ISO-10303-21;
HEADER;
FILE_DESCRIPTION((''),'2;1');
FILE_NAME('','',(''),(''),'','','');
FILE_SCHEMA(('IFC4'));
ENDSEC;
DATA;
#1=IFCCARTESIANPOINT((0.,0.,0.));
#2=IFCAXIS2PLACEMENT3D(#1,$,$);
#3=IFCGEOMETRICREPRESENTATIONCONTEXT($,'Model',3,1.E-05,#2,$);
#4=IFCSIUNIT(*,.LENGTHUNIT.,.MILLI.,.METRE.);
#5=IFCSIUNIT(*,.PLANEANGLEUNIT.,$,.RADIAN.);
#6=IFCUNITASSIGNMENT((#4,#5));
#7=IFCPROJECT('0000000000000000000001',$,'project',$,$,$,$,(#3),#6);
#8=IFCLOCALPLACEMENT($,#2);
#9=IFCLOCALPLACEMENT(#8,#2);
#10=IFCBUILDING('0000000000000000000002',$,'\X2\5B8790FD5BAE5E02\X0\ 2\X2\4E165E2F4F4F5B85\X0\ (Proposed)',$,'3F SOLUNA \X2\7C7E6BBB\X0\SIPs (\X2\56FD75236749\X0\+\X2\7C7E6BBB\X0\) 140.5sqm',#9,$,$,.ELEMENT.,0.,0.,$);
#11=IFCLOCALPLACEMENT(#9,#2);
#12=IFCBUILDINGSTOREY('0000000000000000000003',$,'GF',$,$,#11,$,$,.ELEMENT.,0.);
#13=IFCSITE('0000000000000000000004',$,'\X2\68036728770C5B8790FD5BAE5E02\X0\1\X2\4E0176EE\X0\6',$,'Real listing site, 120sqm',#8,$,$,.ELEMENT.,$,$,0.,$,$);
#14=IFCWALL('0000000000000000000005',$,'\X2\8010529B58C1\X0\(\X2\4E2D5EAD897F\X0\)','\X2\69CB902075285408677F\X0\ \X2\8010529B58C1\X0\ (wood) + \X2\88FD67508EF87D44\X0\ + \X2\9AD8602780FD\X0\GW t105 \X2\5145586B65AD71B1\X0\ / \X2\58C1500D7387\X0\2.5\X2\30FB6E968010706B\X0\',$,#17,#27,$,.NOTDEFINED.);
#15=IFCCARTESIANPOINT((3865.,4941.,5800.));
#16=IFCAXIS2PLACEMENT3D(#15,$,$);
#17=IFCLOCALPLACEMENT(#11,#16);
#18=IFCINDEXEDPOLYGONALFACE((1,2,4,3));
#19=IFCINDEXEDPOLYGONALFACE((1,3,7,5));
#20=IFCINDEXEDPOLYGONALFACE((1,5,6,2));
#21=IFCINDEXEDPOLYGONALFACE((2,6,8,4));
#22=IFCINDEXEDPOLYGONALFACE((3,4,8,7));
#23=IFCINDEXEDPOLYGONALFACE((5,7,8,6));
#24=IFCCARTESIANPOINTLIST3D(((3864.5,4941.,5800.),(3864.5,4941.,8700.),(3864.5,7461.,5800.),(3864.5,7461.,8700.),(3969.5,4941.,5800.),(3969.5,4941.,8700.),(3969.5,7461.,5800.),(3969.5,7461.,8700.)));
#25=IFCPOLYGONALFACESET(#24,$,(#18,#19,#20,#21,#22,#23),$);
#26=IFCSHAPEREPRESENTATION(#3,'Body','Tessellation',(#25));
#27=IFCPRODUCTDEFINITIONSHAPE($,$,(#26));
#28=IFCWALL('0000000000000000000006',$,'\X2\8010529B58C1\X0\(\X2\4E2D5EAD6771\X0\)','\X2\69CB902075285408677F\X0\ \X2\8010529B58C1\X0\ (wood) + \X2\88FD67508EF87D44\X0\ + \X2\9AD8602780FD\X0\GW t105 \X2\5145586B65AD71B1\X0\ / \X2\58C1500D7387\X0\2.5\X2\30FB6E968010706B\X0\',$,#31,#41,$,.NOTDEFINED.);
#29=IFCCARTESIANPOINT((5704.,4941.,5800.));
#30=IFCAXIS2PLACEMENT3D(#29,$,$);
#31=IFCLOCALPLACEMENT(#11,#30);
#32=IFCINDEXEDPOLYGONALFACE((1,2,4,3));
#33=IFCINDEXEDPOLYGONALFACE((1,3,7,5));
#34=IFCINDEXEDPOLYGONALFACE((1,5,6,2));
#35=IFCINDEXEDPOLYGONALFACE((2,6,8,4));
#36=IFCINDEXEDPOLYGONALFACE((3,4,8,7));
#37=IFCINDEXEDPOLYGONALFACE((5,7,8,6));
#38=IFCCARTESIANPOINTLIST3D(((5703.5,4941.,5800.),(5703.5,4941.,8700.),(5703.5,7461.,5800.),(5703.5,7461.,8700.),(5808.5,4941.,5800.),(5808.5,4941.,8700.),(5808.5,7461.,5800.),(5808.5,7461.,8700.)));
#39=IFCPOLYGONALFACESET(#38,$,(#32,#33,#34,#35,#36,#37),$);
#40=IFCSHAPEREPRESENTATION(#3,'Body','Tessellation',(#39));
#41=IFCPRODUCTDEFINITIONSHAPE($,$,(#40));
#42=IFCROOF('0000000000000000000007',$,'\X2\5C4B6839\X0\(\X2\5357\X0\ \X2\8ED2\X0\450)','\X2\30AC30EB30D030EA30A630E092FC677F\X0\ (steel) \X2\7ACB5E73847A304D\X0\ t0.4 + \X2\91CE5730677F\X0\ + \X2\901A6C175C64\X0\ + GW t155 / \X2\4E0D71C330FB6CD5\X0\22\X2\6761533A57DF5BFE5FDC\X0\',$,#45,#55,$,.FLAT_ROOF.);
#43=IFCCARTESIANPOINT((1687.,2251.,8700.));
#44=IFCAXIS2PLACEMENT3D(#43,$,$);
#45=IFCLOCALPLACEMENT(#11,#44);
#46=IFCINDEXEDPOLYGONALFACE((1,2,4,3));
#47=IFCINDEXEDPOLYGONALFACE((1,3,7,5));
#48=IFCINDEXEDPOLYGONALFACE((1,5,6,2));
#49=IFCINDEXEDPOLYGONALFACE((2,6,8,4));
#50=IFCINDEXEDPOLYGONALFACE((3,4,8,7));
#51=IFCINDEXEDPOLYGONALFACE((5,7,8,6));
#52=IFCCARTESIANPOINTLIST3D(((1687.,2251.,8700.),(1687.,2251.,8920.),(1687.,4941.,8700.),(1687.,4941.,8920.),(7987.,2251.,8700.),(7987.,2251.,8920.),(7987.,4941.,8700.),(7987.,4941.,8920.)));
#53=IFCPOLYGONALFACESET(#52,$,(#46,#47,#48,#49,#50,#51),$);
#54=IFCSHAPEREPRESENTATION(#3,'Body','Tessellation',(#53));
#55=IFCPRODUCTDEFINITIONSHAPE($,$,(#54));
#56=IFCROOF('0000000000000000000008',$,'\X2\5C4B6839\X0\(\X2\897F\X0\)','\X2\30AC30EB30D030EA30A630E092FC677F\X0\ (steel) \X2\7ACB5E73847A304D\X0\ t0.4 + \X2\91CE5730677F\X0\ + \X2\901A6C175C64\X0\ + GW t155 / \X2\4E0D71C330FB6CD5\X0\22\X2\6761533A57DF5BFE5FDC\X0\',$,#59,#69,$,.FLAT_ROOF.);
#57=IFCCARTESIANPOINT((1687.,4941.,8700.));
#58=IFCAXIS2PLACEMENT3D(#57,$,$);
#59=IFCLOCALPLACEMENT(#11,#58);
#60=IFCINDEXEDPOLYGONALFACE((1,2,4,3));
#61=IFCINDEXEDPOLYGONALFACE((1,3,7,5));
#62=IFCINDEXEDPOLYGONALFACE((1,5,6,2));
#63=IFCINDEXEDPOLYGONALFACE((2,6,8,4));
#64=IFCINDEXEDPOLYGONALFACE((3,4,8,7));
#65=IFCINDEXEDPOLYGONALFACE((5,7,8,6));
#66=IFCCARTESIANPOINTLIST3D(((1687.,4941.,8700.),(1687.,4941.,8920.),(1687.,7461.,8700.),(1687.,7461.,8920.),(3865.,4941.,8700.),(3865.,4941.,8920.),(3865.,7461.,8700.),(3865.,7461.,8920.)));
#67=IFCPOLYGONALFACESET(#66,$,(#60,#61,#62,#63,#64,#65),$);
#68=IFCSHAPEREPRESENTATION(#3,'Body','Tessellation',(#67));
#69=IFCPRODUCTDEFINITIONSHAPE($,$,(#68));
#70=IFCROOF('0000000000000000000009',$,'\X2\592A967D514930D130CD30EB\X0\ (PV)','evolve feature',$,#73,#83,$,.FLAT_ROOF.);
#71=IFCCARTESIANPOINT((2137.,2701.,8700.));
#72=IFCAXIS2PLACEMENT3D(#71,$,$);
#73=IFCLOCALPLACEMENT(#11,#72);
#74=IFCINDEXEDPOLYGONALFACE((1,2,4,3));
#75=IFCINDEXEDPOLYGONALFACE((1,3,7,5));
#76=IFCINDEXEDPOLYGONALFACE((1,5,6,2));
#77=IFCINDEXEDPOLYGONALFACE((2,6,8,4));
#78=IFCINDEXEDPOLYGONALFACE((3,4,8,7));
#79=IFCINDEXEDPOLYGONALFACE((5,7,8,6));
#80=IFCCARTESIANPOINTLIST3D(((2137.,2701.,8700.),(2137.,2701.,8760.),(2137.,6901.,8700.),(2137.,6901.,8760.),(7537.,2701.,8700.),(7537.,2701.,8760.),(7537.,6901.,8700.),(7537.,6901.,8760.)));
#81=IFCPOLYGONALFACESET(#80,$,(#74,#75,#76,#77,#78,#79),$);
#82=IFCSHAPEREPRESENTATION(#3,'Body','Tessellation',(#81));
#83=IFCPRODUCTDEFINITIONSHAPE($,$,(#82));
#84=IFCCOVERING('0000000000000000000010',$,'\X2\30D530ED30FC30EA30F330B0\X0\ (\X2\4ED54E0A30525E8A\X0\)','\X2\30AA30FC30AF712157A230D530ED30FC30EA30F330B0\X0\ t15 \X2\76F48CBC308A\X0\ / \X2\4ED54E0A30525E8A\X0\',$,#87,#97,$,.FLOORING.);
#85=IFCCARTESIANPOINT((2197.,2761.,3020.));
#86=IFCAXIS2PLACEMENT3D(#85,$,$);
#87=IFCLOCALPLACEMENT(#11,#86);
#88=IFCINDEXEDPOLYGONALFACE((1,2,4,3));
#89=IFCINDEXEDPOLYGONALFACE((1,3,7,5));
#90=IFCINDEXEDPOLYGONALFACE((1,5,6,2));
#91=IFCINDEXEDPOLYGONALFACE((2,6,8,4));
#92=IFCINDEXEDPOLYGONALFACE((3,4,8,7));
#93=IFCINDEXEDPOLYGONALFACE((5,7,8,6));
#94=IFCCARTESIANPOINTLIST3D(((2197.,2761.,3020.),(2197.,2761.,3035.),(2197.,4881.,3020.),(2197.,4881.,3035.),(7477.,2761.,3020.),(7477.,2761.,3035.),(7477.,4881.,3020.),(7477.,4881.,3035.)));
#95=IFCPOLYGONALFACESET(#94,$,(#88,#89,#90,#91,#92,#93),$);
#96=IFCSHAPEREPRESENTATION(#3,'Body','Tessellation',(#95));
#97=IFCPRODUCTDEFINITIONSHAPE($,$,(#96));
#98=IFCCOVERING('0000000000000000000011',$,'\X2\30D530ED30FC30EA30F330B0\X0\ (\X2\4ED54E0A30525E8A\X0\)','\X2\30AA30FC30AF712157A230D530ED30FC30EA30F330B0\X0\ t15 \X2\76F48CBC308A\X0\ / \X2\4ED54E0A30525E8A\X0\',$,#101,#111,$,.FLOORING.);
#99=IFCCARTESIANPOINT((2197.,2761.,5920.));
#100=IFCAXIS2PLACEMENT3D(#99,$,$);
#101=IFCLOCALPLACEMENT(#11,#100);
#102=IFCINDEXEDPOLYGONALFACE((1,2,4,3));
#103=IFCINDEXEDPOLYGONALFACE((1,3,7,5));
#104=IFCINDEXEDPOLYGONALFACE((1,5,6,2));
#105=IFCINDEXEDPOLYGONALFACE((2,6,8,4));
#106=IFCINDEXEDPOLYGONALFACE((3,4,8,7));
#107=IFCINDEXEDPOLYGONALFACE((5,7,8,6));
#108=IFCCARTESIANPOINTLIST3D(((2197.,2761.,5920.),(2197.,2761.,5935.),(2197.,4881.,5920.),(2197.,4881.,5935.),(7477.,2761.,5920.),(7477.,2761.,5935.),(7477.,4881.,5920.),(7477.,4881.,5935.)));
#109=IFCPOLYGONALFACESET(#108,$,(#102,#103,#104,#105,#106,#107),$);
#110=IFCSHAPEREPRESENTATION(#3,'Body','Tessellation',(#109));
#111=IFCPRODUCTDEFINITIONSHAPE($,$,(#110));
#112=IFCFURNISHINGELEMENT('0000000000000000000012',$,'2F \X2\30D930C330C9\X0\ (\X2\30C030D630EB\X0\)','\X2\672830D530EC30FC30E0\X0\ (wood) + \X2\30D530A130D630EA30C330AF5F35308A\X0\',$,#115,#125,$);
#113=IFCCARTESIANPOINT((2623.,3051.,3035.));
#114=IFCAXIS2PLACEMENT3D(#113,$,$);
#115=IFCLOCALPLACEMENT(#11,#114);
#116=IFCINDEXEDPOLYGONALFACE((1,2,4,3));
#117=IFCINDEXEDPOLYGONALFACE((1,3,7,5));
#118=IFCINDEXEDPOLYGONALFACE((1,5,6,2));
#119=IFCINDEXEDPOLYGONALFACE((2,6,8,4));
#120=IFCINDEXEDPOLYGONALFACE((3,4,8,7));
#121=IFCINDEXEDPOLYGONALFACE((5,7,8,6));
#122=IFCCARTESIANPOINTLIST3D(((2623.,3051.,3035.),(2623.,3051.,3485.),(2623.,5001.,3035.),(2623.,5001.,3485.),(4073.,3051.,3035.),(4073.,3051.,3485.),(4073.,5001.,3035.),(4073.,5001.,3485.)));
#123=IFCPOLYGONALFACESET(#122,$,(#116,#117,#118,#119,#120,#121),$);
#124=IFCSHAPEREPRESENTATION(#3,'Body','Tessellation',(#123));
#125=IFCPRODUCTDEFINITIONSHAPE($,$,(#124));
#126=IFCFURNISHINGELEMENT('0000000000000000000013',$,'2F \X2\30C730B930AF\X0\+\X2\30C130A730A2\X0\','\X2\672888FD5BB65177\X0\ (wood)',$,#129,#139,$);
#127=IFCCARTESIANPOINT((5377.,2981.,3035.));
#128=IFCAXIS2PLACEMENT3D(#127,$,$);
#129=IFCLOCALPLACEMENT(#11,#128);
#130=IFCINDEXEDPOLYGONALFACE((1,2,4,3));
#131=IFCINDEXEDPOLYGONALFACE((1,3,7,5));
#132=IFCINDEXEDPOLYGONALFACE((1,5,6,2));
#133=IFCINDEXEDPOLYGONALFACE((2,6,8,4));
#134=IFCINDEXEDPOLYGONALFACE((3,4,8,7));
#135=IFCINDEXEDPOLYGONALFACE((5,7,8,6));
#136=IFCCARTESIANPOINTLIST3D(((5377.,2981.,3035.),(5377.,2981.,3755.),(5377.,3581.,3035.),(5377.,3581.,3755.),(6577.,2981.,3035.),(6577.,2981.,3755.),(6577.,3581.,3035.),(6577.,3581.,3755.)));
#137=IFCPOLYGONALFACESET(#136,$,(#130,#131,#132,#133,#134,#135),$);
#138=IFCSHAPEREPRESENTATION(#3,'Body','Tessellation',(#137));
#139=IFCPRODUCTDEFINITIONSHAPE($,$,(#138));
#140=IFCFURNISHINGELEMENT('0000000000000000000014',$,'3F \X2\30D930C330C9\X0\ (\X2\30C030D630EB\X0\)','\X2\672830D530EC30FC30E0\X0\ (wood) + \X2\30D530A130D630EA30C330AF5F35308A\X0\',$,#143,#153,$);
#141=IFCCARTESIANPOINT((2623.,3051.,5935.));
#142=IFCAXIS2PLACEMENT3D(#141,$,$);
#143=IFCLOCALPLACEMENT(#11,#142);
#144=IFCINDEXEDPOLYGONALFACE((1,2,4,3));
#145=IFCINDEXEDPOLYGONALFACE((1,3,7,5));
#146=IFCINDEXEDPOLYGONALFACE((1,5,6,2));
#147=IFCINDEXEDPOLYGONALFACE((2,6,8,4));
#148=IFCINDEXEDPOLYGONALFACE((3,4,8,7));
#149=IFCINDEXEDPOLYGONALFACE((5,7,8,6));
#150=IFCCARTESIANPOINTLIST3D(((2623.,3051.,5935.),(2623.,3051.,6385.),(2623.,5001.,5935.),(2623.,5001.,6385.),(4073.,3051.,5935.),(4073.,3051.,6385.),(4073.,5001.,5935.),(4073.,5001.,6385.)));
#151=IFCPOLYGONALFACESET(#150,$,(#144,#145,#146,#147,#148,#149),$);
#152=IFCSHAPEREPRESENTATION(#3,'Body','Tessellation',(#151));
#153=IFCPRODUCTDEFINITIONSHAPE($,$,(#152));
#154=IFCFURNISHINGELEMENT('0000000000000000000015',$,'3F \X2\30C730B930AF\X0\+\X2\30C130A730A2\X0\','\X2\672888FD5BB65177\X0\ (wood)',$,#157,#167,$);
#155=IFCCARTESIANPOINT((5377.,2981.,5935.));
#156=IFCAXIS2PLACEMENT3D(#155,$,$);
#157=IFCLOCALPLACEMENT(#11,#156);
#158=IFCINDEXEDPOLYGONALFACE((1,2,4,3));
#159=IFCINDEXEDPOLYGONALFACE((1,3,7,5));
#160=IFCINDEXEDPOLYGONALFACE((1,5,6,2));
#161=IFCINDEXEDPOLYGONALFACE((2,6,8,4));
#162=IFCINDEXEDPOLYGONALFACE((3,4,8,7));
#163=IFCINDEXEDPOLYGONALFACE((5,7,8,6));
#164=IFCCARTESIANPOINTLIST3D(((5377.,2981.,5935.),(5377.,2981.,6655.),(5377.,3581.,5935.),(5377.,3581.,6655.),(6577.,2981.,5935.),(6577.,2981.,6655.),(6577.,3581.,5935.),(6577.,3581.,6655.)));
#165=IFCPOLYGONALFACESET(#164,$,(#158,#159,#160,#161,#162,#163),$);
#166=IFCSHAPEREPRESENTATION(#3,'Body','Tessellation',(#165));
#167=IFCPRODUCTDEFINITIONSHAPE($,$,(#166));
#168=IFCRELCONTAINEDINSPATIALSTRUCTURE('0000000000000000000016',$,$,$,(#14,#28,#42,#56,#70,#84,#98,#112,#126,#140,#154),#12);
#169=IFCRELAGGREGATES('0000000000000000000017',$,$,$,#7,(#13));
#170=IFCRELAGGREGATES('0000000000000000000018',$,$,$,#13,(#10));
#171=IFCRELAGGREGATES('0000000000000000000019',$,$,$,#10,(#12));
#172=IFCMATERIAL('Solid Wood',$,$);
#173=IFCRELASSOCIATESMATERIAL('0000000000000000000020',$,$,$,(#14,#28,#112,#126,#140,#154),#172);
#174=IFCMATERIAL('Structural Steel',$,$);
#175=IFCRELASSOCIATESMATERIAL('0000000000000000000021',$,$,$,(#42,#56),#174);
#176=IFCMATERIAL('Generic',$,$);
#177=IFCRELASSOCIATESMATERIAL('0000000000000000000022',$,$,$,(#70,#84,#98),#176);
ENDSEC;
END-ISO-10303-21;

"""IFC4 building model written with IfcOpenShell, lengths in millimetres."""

from ifc_helpers import new_model, si_unit, frame, frame_2d, origin, place, context, project, spatial, rectangle, extrude, material, element, save


model = new_model("IFC4")

# Units and contexts
model_context = context("Model", 3, precision=1e-05, world=origin())
ifc_project = project(units=[si_unit("LENGTHUNIT", "METRE", prefix="MILLI"), si_unit("PLANEANGLEUNIT", "RADIAN")], contexts=[model_context])

# Site, building, storey
site_placement = place(None, origin())
site = spatial("IfcSite", under=ifc_project, at=site_placement, Name="栃木県宇都宮市1丁目6", ObjectType="Real listing site, 120sqm", CompositionType="ELEMENT", RefElevation=0.0)
building_placement = place(site_placement, origin())
building = spatial("IfcBuilding", under=site, at=building_placement, Name="宇都宮市 2世帯住宅 (Proposed)", ObjectType="3F SOLUNA 籾殻SIPs (国産杉+籾殻) 140.5sqm", CompositionType="ELEMENT", ElevationOfRefHeight=0.0, ElevationOfTerrain=0.0)
storey_placement = place(building_placement, origin())
storey = spatial("IfcBuildingStorey", under=building, at=storey_placement, Name="GF", CompositionType="ELEMENT", Elevation=0.0)

# Shared definitions
ifc_material_1 = material(Name="Solid Wood")

# Walls
wall_1_placement = place(storey_placement, frame((3865.0, 4941.0, 5800.0)))
element("IfcWall", 1, at=wall_1_placement, inside=storey, material=ifc_material_1, Name="耐力壁(中庭西)", Description="構造用合板 耐力壁 (wood) + 製材軸組 + 高性能GW t105 充填断熱 / 壁倍率2.5・準耐火", PredefinedType="NOTDEFINED", context=model_context, shape_type="SweptSolid", body=[
    extrude(rectangle(XDim=105.0, YDim=2520.0, at=frame_2d((52.0, 1260.0))), frame((3865.0, 4941.0, 5800.0)), (0.0, 0.0, 1.0), 2900.0),
])
wall_2_placement = place(storey_placement, frame((5704.0, 4941.0, 5800.0)))
element("IfcWall", 2, at=wall_2_placement, inside=storey, material=ifc_material_1, Name="耐力壁(中庭東)", Description="構造用合板 耐力壁 (wood) + 製材軸組 + 高性能GW t105 充填断熱 / 壁倍率2.5・準耐火", PredefinedType="NOTDEFINED", context=model_context, shape_type="SweptSolid", body=[
    extrude(rectangle(XDim=105.0, YDim=2520.0, at=frame_2d((52.0, 1260.0))), frame((5704.0, 4941.0, 5800.0)), (0.0, 0.0, 1.0), 2900.0),
])

# Roofs
ifc_material_2 = material(Name="Structural Steel")
roof_1_placement = place(storey_placement, frame((1687.0, 2251.0, 8700.0)))
element("IfcRoof", 3, at=roof_1_placement, inside=storey, material=ifc_material_2, Name="屋根(南 軒450)", Description="ガルバリウム鋼板 (steel) 立平葺き t0.4 + 野地板 + 通気層 + GW t155 / 不燃・法22条区域対応", PredefinedType="FLAT_ROOF", context=model_context, shape_type="SweptSolid", body=[
    extrude(rectangle(XDim=6300.0, YDim=2690.0, at=frame_2d((3150.0, 1345.0))), frame((1687.0, 2251.0, 8700.0)), (0.0, 0.0, 1.0), 220.0),
])
roof_2_placement = place(storey_placement, frame((1687.0, 4941.0, 8700.0)))
element("IfcRoof", 4, at=roof_2_placement, inside=storey, material=ifc_material_2, Name="屋根(西)", Description="ガルバリウム鋼板 (steel) 立平葺き t0.4 + 野地板 + 通気層 + GW t155 / 不燃・法22条区域対応", PredefinedType="FLAT_ROOF", context=model_context, shape_type="SweptSolid", body=[
    extrude(rectangle(XDim=2178.0, YDim=2520.0, at=frame_2d((1089.0, 1260.0))), frame((1687.0, 4941.0, 8700.0)), (0.0, 0.0, 1.0), 220.0),
])
ifc_material_3 = material(Name="Generic")
roof_3_placement = place(storey_placement, frame((2137.0, 2701.0, 8700.0)))
element("IfcRoof", 5, at=roof_3_placement, inside=storey, material=ifc_material_3, Name="太陽光パネル (PV)", Description="evolve feature", PredefinedType="FLAT_ROOF", context=model_context, shape_type="SweptSolid", body=[
    extrude(rectangle(XDim=5400.0, YDim=4200.0, at=frame_2d((2700.0, 2100.0))), frame((2137.0, 2701.0, 8700.0)), (0.0, 0.0, 1.0), 60.0),
])

# Coverings
covering_1_placement = place(storey_placement, frame((2197.0, 2761.0, 3020.0)))
element("IfcCovering", 6, at=covering_1_placement, inside=storey, material=ifc_material_3, Name="フローリング (仕上げ床)", Description="オーク無垢フローリング t15 直貼り / 仕上げ床", PredefinedType="FLOORING", context=model_context, shape_type="SweptSolid", body=[
    extrude(rectangle(XDim=5280.0, YDim=2120.0, at=frame_2d((2640.0, 1060.0))), frame((2197.0, 2761.0, 3020.0)), (0.0, 0.0, 1.0), 15.0),
])
covering_2_placement = place(storey_placement, frame((2197.0, 2761.0, 5920.0)))
element("IfcCovering", 7, at=covering_2_placement, inside=storey, material=ifc_material_3, Name="フローリング (仕上げ床)", Description="オーク無垢フローリング t15 直貼り / 仕上げ床", PredefinedType="FLOORING", context=model_context, shape_type="SweptSolid", body=[
    extrude(rectangle(XDim=5280.0, YDim=2120.0, at=frame_2d((2640.0, 1060.0))), frame((2197.0, 2761.0, 5920.0)), (0.0, 0.0, 1.0), 15.0),
])

# Furnishing elements
furnishing_1_placement = place(storey_placement, frame((2623.0, 3051.0, 3035.0)))
element("IfcFurnishingElement", 8, at=furnishing_1_placement, inside=storey, material=ifc_material_1, Name="2F ベッド (ダブル)", Description="木フレーム (wood) + ファブリック張り", context=model_context, shape_type="SweptSolid", body=[
    extrude(rectangle(XDim=1450.0, YDim=1950.0, at=frame_2d((725.0, 975.0))), frame((2623.0, 3051.0, 3035.0)), (0.0, 0.0, 1.0), 450.0),
])
furnishing_2_placement = place(storey_placement, frame((5377.0, 2981.0, 3035.0)))
element("IfcFurnishingElement", 9, at=furnishing_2_placement, inside=storey, material=ifc_material_1, Name="2F デスク+チェア", Description="木製家具 (wood)", context=model_context, shape_type="SweptSolid", body=[
    extrude(rectangle(XDim=1200.0, YDim=600.0, at=frame_2d((600.0, 300.0))), frame((5377.0, 2981.0, 3035.0)), (0.0, 0.0, 1.0), 720.0),
])
furnishing_3_placement = place(storey_placement, frame((2623.0, 3051.0, 5935.0)))
element("IfcFurnishingElement", 10, at=furnishing_3_placement, inside=storey, material=ifc_material_1, Name="3F ベッド (ダブル)", Description="木フレーム (wood) + ファブリック張り", context=model_context, shape_type="SweptSolid", body=[
    extrude(rectangle(XDim=1450.0, YDim=1950.0, at=frame_2d((725.0, 975.0))), frame((2623.0, 3051.0, 5935.0)), (0.0, 0.0, 1.0), 450.0),
])
furnishing_4_placement = place(storey_placement, frame((5377.0, 2981.0, 5935.0)))
element("IfcFurnishingElement", 11, at=furnishing_4_placement, inside=storey, material=ifc_material_1, Name="3F デスク+チェア", Description="木製家具 (wood)", context=model_context, shape_type="SweptSolid", body=[
    extrude(rectangle(XDim=1200.0, YDim=600.0, at=frame_2d((600.0, 300.0))), frame((5377.0, 2981.0, 5935.0)), (0.0, 0.0, 1.0), 720.0),
])

save(model, "model.ifc")
